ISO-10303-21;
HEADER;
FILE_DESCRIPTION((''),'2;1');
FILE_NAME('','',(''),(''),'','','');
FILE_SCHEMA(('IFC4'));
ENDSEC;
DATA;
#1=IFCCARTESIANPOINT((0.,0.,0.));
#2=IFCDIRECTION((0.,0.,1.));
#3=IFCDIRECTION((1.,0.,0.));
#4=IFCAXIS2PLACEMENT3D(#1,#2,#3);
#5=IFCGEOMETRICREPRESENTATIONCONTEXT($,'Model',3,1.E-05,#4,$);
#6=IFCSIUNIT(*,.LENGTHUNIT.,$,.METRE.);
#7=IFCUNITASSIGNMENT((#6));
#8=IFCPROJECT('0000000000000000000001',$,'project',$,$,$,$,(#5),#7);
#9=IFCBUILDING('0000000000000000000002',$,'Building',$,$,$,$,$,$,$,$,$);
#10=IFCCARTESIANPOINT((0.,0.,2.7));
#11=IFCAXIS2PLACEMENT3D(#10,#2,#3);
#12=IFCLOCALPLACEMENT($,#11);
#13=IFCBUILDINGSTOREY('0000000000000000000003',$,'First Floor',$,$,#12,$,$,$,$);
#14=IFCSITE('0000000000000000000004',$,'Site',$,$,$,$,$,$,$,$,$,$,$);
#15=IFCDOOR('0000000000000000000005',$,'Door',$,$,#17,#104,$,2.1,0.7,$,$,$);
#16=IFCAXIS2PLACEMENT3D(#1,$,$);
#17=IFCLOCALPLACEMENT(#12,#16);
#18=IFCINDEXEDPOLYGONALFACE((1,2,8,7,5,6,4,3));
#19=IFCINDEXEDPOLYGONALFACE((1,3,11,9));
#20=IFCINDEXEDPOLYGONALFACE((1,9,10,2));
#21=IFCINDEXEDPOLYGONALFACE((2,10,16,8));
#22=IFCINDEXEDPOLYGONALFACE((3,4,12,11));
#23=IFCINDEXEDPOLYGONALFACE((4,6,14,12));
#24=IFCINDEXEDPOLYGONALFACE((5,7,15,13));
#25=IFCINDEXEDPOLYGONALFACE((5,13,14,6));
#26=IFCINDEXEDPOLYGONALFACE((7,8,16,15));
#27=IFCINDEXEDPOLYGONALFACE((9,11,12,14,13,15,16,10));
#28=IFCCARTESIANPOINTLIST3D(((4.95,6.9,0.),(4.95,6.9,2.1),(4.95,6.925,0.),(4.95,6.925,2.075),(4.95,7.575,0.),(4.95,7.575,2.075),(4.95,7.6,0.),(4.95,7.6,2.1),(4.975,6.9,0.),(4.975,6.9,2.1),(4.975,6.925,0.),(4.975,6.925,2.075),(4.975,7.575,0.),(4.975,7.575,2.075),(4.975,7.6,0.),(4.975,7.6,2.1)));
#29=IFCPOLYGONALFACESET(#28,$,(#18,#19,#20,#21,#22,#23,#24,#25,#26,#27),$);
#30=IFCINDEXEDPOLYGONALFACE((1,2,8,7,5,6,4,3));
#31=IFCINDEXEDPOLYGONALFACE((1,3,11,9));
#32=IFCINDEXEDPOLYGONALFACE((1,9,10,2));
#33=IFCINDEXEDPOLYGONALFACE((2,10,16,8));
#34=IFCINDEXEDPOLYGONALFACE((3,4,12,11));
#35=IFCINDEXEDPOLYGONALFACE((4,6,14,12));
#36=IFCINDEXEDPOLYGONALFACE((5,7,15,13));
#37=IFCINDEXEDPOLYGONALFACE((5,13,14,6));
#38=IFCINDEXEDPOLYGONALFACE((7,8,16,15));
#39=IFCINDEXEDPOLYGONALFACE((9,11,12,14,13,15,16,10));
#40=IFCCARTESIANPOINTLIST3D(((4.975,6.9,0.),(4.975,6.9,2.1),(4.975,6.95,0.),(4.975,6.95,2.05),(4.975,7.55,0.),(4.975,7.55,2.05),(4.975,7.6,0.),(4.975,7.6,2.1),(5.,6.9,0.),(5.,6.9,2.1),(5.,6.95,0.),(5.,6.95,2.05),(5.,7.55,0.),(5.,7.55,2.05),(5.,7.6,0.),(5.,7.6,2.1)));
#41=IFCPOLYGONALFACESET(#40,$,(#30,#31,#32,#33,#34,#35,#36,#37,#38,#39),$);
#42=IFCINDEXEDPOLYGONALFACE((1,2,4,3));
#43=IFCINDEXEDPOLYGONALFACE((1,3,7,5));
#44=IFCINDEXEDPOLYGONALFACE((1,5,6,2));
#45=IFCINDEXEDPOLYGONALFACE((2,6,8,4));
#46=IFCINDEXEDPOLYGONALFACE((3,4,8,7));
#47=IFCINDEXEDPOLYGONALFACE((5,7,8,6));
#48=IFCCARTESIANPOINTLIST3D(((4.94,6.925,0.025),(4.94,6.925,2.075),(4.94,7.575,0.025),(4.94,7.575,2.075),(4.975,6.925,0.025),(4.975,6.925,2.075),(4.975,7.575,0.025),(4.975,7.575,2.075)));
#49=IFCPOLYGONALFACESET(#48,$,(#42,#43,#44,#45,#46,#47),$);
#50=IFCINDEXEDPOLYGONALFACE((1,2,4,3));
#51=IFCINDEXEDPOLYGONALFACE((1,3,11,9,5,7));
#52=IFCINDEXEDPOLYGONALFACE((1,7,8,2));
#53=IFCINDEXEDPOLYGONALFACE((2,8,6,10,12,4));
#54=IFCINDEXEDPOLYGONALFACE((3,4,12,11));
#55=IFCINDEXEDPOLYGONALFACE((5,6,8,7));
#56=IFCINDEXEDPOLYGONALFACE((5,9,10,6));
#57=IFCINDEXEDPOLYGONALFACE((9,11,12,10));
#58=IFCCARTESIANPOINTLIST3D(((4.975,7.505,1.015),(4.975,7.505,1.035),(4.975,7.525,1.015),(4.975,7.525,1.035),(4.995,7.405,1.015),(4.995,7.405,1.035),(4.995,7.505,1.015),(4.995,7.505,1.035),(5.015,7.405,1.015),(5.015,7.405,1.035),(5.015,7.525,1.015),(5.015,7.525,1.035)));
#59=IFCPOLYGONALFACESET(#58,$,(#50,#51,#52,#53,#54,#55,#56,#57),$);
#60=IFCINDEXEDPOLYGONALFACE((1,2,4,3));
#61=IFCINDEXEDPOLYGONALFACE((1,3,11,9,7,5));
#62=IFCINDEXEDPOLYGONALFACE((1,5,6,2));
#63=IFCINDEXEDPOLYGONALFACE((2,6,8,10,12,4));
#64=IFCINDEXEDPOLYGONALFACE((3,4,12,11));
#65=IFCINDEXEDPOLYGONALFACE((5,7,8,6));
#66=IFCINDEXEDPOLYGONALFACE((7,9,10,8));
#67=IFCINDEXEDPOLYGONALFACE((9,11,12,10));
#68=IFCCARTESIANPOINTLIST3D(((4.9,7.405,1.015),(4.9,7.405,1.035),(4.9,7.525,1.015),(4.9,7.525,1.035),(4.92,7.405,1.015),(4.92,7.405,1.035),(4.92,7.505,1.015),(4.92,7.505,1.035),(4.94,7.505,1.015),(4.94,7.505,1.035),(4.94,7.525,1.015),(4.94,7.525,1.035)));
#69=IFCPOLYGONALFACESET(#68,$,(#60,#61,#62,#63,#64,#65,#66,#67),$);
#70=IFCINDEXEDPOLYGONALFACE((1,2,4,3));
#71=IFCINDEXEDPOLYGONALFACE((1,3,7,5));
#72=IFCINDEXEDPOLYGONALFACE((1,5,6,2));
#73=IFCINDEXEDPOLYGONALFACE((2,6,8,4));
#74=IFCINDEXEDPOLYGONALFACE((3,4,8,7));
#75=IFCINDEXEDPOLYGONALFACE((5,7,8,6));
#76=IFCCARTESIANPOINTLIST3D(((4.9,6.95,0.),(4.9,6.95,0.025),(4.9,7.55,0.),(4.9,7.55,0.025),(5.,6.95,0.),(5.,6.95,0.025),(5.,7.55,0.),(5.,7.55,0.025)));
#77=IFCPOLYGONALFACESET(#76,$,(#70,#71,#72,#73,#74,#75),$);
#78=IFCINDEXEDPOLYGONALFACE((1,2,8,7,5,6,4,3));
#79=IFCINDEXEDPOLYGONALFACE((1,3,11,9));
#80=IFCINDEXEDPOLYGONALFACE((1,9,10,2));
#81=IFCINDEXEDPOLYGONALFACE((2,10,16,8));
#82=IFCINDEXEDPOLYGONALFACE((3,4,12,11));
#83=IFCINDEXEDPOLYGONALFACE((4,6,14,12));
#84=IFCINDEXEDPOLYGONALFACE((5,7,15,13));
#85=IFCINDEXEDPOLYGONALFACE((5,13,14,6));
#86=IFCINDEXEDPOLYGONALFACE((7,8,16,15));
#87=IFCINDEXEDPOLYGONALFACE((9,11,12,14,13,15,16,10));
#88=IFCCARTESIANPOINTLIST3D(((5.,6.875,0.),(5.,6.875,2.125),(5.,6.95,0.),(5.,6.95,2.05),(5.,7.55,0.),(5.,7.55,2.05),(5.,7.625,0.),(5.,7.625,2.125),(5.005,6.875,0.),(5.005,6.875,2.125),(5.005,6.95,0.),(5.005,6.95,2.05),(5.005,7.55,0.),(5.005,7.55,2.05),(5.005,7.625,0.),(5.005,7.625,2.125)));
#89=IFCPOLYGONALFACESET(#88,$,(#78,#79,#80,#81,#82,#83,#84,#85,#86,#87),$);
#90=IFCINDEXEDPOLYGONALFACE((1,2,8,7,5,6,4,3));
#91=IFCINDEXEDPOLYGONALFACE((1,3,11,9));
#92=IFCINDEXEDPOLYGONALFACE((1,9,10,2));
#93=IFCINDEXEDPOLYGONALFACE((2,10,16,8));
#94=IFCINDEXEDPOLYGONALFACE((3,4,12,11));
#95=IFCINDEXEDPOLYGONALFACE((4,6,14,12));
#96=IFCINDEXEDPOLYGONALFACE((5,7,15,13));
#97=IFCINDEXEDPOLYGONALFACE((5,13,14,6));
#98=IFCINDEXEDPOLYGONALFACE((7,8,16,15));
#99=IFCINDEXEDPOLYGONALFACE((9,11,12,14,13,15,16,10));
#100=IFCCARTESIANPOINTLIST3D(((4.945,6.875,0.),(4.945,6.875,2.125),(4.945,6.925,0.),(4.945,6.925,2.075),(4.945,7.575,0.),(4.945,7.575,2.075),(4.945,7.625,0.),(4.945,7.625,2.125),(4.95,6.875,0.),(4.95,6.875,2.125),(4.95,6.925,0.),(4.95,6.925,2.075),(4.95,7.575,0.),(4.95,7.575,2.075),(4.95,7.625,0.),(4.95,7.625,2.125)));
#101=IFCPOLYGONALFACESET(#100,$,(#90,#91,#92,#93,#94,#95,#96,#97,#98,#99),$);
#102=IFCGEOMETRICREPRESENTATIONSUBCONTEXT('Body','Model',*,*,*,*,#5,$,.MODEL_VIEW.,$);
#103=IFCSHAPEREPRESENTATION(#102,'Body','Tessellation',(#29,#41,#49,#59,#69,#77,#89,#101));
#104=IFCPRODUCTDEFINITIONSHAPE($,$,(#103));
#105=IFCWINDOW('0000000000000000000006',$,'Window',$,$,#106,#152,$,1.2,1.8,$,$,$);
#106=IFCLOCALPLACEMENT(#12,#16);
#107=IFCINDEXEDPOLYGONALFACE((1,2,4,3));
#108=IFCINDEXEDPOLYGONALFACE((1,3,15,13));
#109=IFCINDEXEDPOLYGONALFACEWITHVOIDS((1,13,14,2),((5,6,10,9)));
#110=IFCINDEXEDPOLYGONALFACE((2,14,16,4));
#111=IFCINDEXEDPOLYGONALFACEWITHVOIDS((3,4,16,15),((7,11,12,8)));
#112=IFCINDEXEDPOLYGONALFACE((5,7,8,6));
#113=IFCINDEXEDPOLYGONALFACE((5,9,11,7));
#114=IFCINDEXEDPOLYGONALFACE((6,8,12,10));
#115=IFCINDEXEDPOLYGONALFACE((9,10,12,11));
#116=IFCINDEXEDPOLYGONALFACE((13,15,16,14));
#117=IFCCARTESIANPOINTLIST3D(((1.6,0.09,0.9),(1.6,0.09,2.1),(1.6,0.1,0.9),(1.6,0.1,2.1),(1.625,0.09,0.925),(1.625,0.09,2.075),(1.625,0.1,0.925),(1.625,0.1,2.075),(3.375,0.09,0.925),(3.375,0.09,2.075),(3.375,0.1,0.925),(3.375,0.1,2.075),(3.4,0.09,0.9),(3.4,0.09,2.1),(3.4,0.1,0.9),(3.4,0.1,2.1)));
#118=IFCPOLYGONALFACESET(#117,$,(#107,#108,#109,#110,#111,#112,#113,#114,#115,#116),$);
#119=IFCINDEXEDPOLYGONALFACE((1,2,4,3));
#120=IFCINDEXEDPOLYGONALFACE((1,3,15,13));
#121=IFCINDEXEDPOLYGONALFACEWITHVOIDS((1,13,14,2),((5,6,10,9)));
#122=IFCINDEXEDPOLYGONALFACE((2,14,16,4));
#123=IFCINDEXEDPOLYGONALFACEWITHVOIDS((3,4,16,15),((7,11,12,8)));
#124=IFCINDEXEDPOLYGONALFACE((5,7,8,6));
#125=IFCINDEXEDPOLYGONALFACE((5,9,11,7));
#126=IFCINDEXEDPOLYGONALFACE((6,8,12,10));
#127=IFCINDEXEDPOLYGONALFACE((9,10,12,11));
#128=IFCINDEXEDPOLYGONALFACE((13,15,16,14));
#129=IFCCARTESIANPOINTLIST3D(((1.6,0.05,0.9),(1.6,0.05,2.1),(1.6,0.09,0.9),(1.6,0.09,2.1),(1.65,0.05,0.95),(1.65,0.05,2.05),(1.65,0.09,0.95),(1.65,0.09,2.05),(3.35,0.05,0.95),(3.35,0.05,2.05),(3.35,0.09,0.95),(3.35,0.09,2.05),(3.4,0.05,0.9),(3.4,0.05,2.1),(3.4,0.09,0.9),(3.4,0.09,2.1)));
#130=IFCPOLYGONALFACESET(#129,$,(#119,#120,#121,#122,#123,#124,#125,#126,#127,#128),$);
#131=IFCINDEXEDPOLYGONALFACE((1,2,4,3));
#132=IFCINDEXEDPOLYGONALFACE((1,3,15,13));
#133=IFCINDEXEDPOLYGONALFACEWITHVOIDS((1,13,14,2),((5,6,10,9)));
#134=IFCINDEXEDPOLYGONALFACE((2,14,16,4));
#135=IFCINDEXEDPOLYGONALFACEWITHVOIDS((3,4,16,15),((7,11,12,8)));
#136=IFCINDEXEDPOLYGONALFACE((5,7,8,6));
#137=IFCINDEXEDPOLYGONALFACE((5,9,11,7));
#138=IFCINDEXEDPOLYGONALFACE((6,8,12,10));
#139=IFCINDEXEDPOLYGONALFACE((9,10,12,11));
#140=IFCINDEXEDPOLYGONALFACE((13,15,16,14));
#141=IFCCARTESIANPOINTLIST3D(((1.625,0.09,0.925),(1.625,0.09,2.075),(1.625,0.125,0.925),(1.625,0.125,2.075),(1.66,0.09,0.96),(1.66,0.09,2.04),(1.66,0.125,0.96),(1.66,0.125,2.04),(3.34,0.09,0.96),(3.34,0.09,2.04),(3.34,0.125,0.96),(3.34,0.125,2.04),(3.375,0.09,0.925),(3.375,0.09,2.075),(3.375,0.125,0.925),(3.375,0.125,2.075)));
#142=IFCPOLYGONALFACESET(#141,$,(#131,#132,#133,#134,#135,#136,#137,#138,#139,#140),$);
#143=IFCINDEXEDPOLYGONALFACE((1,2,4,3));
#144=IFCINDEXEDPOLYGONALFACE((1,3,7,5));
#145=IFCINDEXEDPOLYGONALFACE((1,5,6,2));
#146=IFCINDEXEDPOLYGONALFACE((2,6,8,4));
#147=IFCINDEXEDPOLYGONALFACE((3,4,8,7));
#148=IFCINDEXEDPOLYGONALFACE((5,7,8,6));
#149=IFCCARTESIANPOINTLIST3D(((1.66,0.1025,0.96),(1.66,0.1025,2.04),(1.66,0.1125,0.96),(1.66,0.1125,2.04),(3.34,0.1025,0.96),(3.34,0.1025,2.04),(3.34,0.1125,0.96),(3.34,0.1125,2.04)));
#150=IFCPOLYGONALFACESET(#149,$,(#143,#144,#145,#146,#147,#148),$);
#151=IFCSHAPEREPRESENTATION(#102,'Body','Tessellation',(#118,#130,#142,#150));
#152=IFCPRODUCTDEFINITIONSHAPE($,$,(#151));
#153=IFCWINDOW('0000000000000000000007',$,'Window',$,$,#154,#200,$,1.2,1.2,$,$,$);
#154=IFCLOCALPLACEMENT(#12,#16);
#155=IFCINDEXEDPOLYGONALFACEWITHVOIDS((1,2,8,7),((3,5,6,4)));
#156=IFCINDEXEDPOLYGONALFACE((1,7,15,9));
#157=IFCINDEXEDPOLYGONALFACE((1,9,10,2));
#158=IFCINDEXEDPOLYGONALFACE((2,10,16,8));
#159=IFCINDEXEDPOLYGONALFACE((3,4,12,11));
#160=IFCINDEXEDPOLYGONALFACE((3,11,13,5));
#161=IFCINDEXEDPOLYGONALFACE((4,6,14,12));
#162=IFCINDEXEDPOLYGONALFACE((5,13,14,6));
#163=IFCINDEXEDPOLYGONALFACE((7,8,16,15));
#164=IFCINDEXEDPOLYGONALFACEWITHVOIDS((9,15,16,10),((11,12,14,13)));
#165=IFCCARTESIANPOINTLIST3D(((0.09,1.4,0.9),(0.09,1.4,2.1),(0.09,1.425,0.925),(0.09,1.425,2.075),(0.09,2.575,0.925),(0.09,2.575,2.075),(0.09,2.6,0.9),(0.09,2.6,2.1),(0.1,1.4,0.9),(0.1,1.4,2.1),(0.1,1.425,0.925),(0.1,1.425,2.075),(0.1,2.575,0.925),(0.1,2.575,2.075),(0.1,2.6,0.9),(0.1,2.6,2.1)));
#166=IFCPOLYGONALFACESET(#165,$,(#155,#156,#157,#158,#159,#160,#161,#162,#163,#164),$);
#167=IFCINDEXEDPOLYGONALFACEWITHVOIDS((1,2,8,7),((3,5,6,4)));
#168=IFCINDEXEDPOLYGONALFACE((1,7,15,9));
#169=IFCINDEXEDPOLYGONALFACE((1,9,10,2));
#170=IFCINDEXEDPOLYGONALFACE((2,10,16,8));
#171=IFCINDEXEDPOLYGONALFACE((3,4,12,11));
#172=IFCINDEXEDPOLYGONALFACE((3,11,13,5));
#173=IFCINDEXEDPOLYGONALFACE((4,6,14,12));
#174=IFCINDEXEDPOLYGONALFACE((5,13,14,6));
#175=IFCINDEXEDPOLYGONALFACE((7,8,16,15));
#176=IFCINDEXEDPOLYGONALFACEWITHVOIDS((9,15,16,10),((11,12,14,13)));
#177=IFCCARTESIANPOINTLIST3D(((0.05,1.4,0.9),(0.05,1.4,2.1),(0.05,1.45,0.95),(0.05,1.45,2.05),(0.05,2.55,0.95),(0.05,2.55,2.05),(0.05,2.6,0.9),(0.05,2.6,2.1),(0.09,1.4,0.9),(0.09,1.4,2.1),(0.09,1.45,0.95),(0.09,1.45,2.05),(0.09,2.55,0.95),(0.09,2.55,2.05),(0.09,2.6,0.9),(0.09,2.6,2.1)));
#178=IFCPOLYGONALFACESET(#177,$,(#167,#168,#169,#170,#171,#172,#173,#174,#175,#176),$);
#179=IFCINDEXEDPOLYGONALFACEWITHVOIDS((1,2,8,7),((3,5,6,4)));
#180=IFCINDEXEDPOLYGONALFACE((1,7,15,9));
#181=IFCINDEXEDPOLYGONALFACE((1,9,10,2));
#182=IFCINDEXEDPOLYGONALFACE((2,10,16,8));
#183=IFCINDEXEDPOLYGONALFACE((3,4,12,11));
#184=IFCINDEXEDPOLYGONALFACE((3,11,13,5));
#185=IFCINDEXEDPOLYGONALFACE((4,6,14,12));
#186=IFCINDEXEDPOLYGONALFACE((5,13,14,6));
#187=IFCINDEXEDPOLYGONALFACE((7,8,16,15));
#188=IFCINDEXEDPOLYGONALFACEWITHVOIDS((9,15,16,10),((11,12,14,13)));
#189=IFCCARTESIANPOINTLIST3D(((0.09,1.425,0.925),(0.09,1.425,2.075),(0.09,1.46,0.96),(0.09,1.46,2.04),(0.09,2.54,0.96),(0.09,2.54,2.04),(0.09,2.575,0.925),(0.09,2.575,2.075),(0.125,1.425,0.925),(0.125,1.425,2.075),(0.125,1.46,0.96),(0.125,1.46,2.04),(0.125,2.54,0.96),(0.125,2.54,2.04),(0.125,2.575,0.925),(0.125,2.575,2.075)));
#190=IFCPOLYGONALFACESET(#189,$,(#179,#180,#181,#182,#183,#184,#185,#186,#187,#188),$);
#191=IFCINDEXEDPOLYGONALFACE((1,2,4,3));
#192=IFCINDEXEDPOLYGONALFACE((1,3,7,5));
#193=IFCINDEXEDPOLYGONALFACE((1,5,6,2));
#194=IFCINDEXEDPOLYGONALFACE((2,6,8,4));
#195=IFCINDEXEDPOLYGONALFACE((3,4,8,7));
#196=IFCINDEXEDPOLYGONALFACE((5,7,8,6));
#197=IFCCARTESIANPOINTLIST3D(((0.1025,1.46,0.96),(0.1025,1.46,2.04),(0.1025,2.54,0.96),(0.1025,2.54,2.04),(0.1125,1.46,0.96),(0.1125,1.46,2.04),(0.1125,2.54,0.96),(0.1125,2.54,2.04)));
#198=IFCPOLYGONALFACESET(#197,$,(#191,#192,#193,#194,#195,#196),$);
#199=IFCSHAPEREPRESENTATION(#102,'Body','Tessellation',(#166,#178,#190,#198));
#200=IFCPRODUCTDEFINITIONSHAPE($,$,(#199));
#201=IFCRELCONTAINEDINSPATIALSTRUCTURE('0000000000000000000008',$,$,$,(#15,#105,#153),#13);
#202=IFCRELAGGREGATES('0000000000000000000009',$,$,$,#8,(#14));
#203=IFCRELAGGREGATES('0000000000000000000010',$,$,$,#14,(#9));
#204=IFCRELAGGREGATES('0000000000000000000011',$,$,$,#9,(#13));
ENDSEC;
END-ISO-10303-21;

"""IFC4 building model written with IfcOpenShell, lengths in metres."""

from ifc_helpers import new_model, si_unit, frame, origin_with_axes, place, context, subcontext, project, spatial, line, indexed_curve, outline, extrude, element, save


model = new_model("IFC4")

# Units and contexts
model_context = context("Model", 3, precision=1e-05, world=origin_with_axes())
body_context = subcontext(model_context, "Body", "Model", "MODEL_VIEW")
ifc_project = project(units=[si_unit("LENGTHUNIT", "METRE")], contexts=[model_context])

# Site, building, storey
site = spatial("IfcSite", under=ifc_project, Name="Site")
building = spatial("IfcBuilding", under=site, Name="Building")
storey_placement = place(None, frame((0.0, 0.0, 2.7), z_axis=(0.0, 0.0, 1.0), x_axis=(1.0, 0.0, 0.0)))
storey = spatial("IfcBuildingStorey", under=building, at=storey_placement, Name="First Floor")

# Door
door_1_placement = place(storey_placement, frame((5.0, 6.9, 0.0), z_axis=(0.0, 0.0, 1.0), x_axis=(0.0, 1.0, 0.0)))
element("IfcDoor", 1, at=door_1_placement, inside=storey, Name="Door", OverallHeight=2.1, OverallWidth=0.7, context=body_context, shape_type="SweptSolid", body=[
    extrude(outline(indexed_curve([(0.0, 0.0), (0.0, 2.1), (0.7, 2.1), (0.7, 0.0), (0.675, 0.0), (0.675, 2.075), (0.025, 2.075), (0.025, 0.0)], segments=[line(1, 2, 3, 4, 5, 6, 7, 8, 1)])), frame((0.0, 0.025, 0.0), z_axis=(0.0, -1.0, 0.0), x_axis=(1.0, 0.0, 0.0)), (0.0, 0.0, -1.0), 0.025),
    extrude(outline(indexed_curve([(0.0, 0.0), (0.0, 2.1), (0.7, 2.1), (0.7, 0.0), (0.65, 0.0), (0.65, 2.05), (0.05, 2.05), (0.05, 0.0)], segments=[line(1, 2, 3, 4, 5, 6, 7, 8, 1)])), frame((0.0, 0.0, 0.0), z_axis=(0.0, -1.0, 0.0), x_axis=(1.0, 0.0, 0.0)), (0.0, 0.0, -1.0), 0.025),
    extrude(outline(indexed_curve([(0.0, 0.0), (0.65, 0.0), (0.65, 0.035), (0.0, 0.035)], segments=[line(1, 2, 3, 4, 1)])), frame((0.025, 0.025, 0.025), z_axis=(0.0, 0.0, 1.0), x_axis=(1.0, 0.0, 0.0)), (0.0, 0.0, 1.0), 2.05),
    extrude(outline(indexed_curve([(0.0, 0.0), (0.0, -0.04), (-0.12, -0.04), (-0.12, -0.02), (-0.02, -0.02), (-0.02, 0.0)], segments=[line(1, 2, 3, 4, 5, 6, 1)])), frame((0.625, 0.025, 1.015), z_axis=(0.0, 0.0, 1.0), x_axis=(1.0, 0.0, 0.0)), (0.0, 0.0, 1.0), 0.02),
    extrude(outline(indexed_curve([(0.0, 0.0), (0.0, 0.04), (-0.12, 0.04), (-0.12, 0.02), (-0.02, 0.02), (-0.02, 0.0)], segments=[line(1, 2, 3, 4, 5, 6, 1)])), frame((0.625, 0.06, 1.015), z_axis=(0.0, 0.0, 1.0), x_axis=(1.0, 0.0, 0.0)), (0.0, 0.0, 1.0), 0.02),
    extrude(outline(indexed_curve([(0.0, 0.0), (0.6, 0.0), (0.6, 0.1), (0.0, 0.1)], segments=[line(1, 2, 3, 4, 1)])), frame((0.05, 0.0, 0.0), z_axis=(0.0, 0.0, 1.0), x_axis=(1.0, 0.0, 0.0)), (0.0, 0.0, 1.0), 0.025),
    extrude(outline(indexed_curve([(0.0, 0.0), (0.0, 2.125), (0.75, 2.125), (0.75, 0.0), (0.675, 0.0), (0.675, 2.05), (0.075, 2.05), (0.075, 0.0)], segments=[line(1, 2, 3, 4, 5, 6, 7, 8, 1)])), frame((-0.025, -0.005, 0.0), z_axis=(0.0, -1.0, 0.0), x_axis=(1.0, 0.0, 0.0)), (0.0, 0.0, -1.0), 0.005),
    extrude(outline(indexed_curve([(0.0, 0.0), (0.0, 2.125), (0.75, 2.125), (0.75, 0.0), (0.7, 0.0), (0.7, 2.075), (0.05, 2.075), (0.05, 0.0)], segments=[line(1, 2, 3, 4, 5, 6, 7, 8, 1)])), frame((-0.025, 0.05, 0.0), z_axis=(0.0, -1.0, 0.0), x_axis=(1.0, 0.0, 0.0)), (0.0, 0.0, -1.0), 0.005),
])

# Windows
window_1_placement = place(storey_placement, frame((1.6, 0.0, 0.9), z_axis=(0.0, 0.0, 1.0), x_axis=(1.0, 0.0, 0.0)))
element("IfcWindow", 2, at=window_1_placement, inside=storey, Name="Window", OverallHeight=1.2, OverallWidth=1.8, context=body_context, shape_type="SweptSolid", body=[
    extrude(outline(indexed_curve([(0.0, 0.0), (1.8, 0.0), (1.8, 1.2), (0.0, 1.2)], segments=[line(1, 2, 3, 4, 1)]), holes=[indexed_curve([(0.025, 0.025), (1.775, 0.025), (1.775, 1.175), (0.025, 1.175)], segments=[line(1, 2, 3, 4, 1)])]), frame((0.0, 0.09, 0.0), z_axis=(0.0, -1.0, 0.0), x_axis=(1.0, 0.0, 0.0)), (0.0, 0.0, -1.0), 0.01),
    extrude(outline(indexed_curve([(0.0, 0.0), (1.8, 0.0), (1.8, 1.2), (0.0, 1.2)], segments=[line(1, 2, 3, 4, 1)]), holes=[indexed_curve([(0.05, 0.05), (1.75, 0.05), (1.75, 1.15), (0.05, 1.15)], segments=[line(1, 2, 3, 4, 1)])]), frame((0.0, 0.05, 0.0), z_axis=(0.0, -1.0, 0.0), x_axis=(1.0, 0.0, 0.0)), (0.0, 0.0, -1.0), 0.04),
    extrude(outline(indexed_curve([(0.0, 0.0), (1.75, 0.0), (1.75, 1.15), (0.0, 1.15)], segments=[line(1, 2, 3, 4, 1)]), holes=[indexed_curve([(0.035, 0.035), (1.715, 0.035), (1.715, 1.115), (0.035, 1.115)], segments=[line(1, 2, 3, 4, 1)])]), frame((0.025, 0.09, 0.025), z_axis=(0.0, -1.0, 0.0), x_axis=(1.0, 0.0, 0.0)), (0.0, 0.0, -1.0), 0.035),
    extrude(outline(indexed_curve([(0.035, 0.035), (1.715, 0.035), (1.715, 1.115), (0.035, 1.115)], segments=[line(1, 2, 3, 4, 1)])), frame((0.025, 0.1025, 0.025), z_axis=(0.0, -1.0, 0.0), x_axis=(1.0, 0.0, 0.0)), (0.0, 0.0, -1.0), 0.01),
])
window_2_placement = place(storey_placement, frame((0.0, 2.6, 0.9), z_axis=(0.0, 0.0, 1.0), x_axis=(0.0, -1.0, 0.0)))
element("IfcWindow", 3, at=window_2_placement, inside=storey, Name="Window", OverallHeight=1.2, OverallWidth=1.2, context=body_context, shape_type="SweptSolid", body=[
    extrude(outline(indexed_curve([(0.0, 0.0), (1.2, 0.0), (1.2, 1.2), (0.0, 1.2)], segments=[line(1, 2, 3, 4, 1)]), holes=[indexed_curve([(0.025, 0.025), (1.175, 0.025), (1.175, 1.175), (0.025, 1.175)], segments=[line(1, 2, 3, 4, 1)])]), frame((0.0, 0.09, 0.0), z_axis=(0.0, -1.0, 0.0), x_axis=(1.0, 0.0, 0.0)), (0.0, 0.0, -1.0), 0.01),
    extrude(outline(indexed_curve([(0.0, 0.0), (1.2, 0.0), (1.2, 1.2), (0.0, 1.2)], segments=[line(1, 2, 3, 4, 1)]), holes=[indexed_curve([(0.05, 0.05), (1.15, 0.05), (1.15, 1.15), (0.05, 1.15)], segments=[line(1, 2, 3, 4, 1)])]), frame((0.0, 0.05, 0.0), z_axis=(0.0, -1.0, 0.0), x_axis=(1.0, 0.0, 0.0)), (0.0, 0.0, -1.0), 0.04),
    extrude(outline(indexed_curve([(0.0, 0.0), (1.15, 0.0), (1.15, 1.15), (0.0, 1.15)], segments=[line(1, 2, 3, 4, 1)]), holes=[indexed_curve([(0.035, 0.035), (1.115, 0.035), (1.115, 1.115), (0.035, 1.115)], segments=[line(1, 2, 3, 4, 1)])]), frame((0.025, 0.09, 0.025), z_axis=(0.0, -1.0, 0.0), x_axis=(1.0, 0.0, 0.0)), (0.0, 0.0, -1.0), 0.035),
    extrude(outline(indexed_curve([(0.035, 0.035), (1.115, 0.035), (1.115, 1.115), (0.035, 1.115)], segments=[line(1, 2, 3, 4, 1)])), frame((0.025, 0.1025, 0.025), z_axis=(0.0, -1.0, 0.0), x_axis=(1.0, 0.0, 0.0)), (0.0, 0.0, -1.0), 0.01),
])

save(model, "model.ifc")
